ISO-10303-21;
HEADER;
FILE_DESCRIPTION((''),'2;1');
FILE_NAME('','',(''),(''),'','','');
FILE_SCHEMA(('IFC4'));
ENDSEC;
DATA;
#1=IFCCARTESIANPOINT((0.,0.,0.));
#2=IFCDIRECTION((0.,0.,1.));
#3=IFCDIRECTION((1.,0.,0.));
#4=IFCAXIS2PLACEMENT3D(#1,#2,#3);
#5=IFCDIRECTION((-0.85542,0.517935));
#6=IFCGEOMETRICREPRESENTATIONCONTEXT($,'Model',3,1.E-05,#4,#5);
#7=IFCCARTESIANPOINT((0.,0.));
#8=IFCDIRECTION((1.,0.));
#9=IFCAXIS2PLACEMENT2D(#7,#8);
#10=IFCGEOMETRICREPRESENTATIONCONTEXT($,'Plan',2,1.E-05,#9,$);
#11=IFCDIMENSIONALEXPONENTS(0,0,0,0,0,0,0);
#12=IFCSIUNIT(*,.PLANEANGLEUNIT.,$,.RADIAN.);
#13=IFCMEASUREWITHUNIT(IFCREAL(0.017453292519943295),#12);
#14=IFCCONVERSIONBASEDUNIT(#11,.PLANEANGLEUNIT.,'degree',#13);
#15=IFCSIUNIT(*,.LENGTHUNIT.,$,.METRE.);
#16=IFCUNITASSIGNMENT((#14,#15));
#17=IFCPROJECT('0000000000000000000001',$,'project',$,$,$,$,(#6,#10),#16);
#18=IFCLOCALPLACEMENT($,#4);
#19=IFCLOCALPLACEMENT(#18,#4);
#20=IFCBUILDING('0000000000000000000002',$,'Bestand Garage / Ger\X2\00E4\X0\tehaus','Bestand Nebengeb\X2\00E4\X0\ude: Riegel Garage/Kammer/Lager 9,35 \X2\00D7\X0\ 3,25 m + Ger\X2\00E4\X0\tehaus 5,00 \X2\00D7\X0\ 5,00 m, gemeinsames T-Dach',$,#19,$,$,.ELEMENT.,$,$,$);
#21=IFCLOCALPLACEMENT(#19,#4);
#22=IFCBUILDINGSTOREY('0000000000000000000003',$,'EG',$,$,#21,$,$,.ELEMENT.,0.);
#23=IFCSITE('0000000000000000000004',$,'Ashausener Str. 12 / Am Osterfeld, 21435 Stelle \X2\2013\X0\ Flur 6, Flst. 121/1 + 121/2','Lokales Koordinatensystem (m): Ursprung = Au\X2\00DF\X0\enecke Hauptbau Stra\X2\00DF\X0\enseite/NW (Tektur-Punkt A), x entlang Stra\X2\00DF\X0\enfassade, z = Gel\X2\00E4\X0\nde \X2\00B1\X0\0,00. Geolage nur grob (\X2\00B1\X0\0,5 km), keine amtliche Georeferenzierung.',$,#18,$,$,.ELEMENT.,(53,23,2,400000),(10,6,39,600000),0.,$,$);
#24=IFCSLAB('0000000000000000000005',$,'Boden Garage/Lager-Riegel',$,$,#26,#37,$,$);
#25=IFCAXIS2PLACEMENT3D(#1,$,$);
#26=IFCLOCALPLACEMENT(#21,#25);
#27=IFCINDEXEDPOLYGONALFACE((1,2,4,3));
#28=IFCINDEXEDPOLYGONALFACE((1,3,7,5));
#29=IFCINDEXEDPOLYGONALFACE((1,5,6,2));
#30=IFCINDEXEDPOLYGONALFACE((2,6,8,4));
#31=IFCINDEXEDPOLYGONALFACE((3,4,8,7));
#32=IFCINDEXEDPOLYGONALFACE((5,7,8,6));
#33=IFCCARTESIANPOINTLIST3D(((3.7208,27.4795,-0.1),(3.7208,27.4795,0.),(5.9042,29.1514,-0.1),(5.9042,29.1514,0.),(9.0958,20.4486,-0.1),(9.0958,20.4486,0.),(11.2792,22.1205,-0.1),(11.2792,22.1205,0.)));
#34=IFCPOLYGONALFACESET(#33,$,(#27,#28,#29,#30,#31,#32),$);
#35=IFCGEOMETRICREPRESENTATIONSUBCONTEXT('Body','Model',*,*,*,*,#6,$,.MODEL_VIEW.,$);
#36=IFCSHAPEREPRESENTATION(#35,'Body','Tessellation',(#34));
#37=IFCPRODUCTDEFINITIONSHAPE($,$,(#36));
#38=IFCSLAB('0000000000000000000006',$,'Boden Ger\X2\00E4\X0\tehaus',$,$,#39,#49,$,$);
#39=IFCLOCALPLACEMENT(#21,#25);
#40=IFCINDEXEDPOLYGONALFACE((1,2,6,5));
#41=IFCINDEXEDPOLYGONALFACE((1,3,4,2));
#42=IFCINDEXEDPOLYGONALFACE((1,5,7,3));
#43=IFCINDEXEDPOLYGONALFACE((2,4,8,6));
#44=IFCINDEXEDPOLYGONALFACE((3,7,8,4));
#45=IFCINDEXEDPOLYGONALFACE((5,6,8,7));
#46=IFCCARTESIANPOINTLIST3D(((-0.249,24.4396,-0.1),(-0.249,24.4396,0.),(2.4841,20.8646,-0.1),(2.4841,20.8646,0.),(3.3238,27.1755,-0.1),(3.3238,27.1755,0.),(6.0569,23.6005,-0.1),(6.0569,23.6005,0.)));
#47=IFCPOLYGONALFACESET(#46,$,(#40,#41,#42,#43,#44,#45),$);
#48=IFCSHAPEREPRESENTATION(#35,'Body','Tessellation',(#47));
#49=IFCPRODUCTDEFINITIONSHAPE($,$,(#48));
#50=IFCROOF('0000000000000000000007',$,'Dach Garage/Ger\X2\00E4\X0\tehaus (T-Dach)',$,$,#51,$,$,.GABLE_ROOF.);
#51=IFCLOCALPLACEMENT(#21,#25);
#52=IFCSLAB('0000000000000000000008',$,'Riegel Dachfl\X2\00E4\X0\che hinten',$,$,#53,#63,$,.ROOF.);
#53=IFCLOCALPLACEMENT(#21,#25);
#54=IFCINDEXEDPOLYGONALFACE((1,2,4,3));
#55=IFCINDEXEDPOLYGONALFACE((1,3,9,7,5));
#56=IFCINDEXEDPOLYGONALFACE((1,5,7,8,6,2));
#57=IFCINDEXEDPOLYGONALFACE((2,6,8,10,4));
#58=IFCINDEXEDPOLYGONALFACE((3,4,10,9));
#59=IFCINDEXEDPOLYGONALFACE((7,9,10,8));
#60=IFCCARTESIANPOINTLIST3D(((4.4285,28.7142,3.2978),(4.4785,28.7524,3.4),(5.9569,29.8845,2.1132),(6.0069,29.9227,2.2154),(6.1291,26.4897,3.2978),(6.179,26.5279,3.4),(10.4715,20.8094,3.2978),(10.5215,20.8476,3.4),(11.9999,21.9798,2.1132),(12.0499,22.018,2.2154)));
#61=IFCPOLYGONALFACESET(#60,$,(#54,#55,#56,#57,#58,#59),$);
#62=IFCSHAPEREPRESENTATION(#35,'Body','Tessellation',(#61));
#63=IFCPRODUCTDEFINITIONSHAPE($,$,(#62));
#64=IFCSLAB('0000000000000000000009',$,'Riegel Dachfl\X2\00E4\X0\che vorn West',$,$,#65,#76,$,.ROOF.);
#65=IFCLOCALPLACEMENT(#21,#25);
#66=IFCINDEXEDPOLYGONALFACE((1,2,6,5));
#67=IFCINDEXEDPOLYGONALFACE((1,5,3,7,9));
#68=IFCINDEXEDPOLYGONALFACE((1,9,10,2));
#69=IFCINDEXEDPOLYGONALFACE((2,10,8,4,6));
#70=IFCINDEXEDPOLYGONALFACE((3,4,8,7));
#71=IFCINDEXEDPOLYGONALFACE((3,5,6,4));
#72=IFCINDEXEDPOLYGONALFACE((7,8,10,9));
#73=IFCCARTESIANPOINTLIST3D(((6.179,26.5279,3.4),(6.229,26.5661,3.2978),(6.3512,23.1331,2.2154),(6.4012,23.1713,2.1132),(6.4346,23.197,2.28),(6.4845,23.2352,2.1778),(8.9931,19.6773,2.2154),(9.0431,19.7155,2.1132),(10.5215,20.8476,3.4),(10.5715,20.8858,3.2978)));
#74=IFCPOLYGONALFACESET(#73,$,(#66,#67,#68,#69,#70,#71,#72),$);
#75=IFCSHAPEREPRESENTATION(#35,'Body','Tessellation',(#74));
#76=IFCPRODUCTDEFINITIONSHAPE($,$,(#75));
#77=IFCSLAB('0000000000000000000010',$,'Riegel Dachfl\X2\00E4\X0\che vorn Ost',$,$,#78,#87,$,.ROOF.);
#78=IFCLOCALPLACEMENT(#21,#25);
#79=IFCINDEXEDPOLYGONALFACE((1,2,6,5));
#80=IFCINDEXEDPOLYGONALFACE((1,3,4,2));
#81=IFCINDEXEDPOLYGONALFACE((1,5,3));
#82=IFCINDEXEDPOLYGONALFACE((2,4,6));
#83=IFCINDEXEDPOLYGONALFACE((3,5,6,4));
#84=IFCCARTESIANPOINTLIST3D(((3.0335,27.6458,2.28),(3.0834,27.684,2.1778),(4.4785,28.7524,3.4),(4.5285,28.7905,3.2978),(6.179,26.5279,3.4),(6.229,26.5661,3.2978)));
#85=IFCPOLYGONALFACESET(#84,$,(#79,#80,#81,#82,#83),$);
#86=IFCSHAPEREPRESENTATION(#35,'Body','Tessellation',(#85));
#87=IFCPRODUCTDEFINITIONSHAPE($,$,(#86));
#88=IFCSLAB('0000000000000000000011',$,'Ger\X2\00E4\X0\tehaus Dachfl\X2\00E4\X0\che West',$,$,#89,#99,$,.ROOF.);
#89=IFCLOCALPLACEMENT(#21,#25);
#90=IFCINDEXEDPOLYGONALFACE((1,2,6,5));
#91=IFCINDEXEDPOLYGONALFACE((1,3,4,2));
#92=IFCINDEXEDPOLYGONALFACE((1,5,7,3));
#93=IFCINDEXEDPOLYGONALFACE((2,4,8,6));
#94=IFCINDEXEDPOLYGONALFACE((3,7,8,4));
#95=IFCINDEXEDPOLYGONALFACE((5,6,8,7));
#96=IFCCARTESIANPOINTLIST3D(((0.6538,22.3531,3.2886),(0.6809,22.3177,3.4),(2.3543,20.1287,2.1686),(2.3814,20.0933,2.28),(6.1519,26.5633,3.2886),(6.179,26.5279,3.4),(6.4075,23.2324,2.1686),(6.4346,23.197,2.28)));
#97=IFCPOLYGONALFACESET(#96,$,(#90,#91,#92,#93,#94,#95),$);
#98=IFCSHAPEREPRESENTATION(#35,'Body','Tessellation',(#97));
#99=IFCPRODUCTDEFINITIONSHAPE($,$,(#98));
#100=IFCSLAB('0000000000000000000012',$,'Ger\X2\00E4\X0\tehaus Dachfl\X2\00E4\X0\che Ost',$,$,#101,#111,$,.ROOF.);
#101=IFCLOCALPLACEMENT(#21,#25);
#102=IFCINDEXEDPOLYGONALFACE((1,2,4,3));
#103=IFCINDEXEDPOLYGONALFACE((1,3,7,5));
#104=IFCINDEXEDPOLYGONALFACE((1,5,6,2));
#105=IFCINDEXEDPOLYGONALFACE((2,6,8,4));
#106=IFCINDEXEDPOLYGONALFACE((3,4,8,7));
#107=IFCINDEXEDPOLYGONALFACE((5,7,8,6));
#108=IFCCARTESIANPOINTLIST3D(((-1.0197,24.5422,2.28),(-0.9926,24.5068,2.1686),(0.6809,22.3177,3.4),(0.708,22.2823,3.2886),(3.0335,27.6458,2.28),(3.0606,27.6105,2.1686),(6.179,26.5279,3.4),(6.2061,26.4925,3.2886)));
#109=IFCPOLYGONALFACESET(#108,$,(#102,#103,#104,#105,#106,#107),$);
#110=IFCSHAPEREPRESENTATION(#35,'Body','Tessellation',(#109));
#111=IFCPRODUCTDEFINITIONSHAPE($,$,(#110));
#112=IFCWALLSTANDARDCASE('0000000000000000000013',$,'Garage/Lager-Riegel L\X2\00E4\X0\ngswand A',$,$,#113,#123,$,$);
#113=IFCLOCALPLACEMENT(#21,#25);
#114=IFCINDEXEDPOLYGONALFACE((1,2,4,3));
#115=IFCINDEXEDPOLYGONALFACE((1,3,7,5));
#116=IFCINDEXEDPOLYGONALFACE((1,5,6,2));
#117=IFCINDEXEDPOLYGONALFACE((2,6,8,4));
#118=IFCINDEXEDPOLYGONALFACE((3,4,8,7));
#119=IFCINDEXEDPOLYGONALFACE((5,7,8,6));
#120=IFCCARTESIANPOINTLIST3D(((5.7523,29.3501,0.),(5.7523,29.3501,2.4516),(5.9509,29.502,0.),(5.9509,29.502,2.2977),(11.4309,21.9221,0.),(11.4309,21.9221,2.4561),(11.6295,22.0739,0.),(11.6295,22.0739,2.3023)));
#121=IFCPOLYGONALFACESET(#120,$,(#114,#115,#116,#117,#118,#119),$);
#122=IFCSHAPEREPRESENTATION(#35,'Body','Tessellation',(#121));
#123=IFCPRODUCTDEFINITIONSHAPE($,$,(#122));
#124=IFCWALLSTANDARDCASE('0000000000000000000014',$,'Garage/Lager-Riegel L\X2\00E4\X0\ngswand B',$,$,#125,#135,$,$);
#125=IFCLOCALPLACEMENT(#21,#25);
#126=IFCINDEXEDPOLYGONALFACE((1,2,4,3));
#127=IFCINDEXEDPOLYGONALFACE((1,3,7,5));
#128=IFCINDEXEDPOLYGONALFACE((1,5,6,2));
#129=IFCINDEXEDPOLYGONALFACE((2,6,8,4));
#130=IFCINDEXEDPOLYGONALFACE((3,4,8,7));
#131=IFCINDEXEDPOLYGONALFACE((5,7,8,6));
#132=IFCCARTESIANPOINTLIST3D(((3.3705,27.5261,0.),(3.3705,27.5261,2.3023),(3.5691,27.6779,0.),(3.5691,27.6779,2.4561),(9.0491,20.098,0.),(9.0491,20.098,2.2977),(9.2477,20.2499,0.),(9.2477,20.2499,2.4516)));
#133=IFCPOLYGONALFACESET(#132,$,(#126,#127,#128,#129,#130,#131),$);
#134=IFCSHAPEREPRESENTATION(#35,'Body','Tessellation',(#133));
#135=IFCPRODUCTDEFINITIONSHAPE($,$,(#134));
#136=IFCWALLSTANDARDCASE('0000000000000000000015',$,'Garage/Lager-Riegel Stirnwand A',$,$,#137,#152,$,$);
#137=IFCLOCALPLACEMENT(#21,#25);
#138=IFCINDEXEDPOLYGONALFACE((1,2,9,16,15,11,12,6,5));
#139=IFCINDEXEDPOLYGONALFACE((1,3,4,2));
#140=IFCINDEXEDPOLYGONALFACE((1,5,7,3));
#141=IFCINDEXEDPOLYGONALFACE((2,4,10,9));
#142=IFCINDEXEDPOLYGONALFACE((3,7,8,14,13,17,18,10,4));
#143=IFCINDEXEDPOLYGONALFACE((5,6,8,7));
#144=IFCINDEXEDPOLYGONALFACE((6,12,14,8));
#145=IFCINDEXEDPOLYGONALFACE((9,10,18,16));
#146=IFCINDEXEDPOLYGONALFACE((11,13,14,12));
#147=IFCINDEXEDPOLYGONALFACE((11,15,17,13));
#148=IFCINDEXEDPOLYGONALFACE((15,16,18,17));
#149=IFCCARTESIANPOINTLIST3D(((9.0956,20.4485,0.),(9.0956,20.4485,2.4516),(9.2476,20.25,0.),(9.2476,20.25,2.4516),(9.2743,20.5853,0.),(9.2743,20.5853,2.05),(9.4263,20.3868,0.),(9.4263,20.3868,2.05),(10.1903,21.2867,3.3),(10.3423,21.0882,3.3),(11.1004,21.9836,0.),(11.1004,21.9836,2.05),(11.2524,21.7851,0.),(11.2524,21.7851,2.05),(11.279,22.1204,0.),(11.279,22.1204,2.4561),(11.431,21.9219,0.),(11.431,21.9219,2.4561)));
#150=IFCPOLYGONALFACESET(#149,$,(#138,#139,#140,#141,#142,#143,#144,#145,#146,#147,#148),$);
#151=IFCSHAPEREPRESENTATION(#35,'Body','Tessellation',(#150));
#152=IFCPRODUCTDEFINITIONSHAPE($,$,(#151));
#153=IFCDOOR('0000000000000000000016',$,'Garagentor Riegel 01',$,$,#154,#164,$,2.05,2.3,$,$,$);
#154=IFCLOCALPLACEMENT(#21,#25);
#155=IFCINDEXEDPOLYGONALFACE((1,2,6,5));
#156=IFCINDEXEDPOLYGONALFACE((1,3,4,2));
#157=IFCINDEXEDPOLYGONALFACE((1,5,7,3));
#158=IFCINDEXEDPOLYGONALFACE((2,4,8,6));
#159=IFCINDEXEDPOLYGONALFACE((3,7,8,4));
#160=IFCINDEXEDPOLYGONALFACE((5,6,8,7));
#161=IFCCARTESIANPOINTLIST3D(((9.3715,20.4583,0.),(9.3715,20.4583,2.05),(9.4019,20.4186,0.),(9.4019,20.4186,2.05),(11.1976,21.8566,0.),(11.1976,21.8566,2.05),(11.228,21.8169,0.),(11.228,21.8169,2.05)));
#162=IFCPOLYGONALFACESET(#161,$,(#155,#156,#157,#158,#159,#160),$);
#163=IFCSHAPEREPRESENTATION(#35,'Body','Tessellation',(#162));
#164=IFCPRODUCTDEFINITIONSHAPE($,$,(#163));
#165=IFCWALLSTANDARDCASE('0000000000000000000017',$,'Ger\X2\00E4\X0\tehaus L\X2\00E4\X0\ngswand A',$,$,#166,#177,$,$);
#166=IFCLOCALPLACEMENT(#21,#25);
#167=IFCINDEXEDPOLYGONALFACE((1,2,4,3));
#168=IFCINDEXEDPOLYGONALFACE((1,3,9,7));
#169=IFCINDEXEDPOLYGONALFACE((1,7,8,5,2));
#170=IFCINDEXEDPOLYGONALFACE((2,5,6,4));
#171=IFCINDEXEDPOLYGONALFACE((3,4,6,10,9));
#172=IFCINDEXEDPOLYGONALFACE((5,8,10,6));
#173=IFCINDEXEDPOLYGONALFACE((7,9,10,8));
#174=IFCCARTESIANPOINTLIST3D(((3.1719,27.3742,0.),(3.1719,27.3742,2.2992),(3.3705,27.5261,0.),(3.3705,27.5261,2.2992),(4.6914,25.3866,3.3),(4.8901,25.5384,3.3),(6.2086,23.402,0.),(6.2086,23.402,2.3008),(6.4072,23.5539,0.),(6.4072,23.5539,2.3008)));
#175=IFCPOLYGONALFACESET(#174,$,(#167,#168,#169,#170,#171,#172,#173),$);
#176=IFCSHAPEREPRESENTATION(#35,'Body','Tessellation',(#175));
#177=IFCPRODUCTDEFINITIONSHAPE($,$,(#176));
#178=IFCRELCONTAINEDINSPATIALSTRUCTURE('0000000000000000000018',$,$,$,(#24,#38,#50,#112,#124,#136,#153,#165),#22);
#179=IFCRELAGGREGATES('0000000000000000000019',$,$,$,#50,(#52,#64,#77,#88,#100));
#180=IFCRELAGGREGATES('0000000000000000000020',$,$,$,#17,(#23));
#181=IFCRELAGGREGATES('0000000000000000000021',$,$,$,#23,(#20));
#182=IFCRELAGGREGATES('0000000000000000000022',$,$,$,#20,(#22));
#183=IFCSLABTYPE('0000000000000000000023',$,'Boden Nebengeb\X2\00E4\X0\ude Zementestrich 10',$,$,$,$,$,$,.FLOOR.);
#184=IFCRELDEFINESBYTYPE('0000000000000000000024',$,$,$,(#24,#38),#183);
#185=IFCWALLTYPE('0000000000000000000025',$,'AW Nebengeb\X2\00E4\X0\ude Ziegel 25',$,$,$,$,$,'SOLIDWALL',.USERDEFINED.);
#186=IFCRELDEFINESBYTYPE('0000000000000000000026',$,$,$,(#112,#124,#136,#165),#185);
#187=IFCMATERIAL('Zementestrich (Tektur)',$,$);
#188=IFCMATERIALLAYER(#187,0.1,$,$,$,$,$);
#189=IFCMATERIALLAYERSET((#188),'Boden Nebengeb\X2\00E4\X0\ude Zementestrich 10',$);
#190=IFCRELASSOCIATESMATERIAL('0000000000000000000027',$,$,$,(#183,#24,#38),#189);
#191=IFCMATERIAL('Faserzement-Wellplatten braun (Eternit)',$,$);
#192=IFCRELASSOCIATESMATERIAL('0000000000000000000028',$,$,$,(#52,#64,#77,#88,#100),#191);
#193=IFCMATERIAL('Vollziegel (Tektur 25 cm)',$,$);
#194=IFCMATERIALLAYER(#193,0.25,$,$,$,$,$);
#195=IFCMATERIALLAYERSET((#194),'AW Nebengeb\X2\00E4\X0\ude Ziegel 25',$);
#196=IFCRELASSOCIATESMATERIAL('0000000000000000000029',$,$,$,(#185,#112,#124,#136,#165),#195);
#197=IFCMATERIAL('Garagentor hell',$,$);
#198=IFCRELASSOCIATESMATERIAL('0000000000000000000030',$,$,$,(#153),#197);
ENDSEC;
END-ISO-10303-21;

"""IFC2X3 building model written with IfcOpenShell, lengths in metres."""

from ifc_helpers import new_model, entity, si_unit, converted_unit, direction, frame, origin_with_axes, origin_2d_with_axis, place, context, subcontext, project, spatial, polyline, outline, extrude, clip, halfspace, material, layer, layer_set, layer_usage, type_object, element, fill, aggregate, save


model = new_model("IFC2X3")

# Units and contexts
model_context = context("Model", 3, precision=1e-05, world=origin_with_axes(), true_north=direction((-0.85542, 0.517935)))
plan_context = context("Plan", 2, precision=1e-05, world=origin_2d_with_axis())
body_context = subcontext(model_context, "Body", "Model", "MODEL_VIEW")
ifc_project = project(units=[converted_unit("PLANEANGLEUNIT", "degree", entity("IfcReal", 0.017453292519943295), si_unit("PLANEANGLEUNIT", "RADIAN"), dimensions=[0, 0, 0, 0, 0, 0, 0]), si_unit("LENGTHUNIT", "METRE")], contexts=[model_context, plan_context])

# Site, building, storey
site_placement = place(None, origin_with_axes())
site = spatial("IfcSite", under=ifc_project, at=site_placement, Name="Ashausener Str. 12 / Am Osterfeld, 21435 Stelle – Flur 6, Flst. 121/1 + 121/2", Description="Lokales Koordinatensystem (m): Ursprung = Außenecke Hauptbau Straßenseite/NW (Tektur-Punkt A), x entlang Straßenfassade, z = Gelände ±0,00. Geolage nur grob (±0,5 km), keine amtliche Georeferenzierung.", CompositionType="ELEMENT", RefLatitude=(53, 23, 2, 400000), RefLongitude=(10, 6, 39, 600000), RefElevation=0.0)
building_placement = place(site_placement, origin_with_axes())
building = spatial("IfcBuilding", under=site, at=building_placement, Name="Bestand Garage / Gerätehaus", Description="Bestand Nebengebäude: Riegel Garage/Kammer/Lager 9,35 × 3,25 m + Gerätehaus 5,00 × 5,00 m, gemeinsames T-Dach", CompositionType="ELEMENT")
storey_placement = place(building_placement, origin_with_axes())
storey = spatial("IfcBuildingStorey", under=building, at=storey_placement, Name="EG", CompositionType="ELEMENT", Elevation=0.0)

# Slabs
ifc_material_1 = material(Name="Zementestrich (Tektur)")
ifc_layer_1 = layer(ifc_material_1, 0.1)
ifc_layer_set_1 = layer_set([ifc_layer_1], Name="Boden Nebengebäude Zementestrich 10")
ifc_layer_usage_1 = layer_usage(ifc_layer_set_1, "AXIS3", "POSITIVE", 0.0)
slab_type = type_object("IfcSlabType", Name="Boden Nebengebäude Zementestrich 10", PredefinedType="FLOOR", material=ifc_layer_set_1)
slab_1_placement = place(storey_placement, origin_with_axes())
element("IfcSlab", 1, at=slab_1_placement, inside=storey, type_object=slab_type, material=ifc_layer_usage_1, Name="Boden Garage/Lager-Riegel", context=body_context, shape_type="SweptSolid", body=[
    extrude(outline(polyline([(11.2792, 22.1205), (5.9042, 29.1514), (3.7208, 27.4795), (9.0958, 20.4486), (11.2792, 22.1205)])), frame((0.0, 0.0, -0.1)), (0.0, 0.0, 1.0), 0.1),
])
ifc_layer_usage_2 = layer_usage(ifc_layer_set_1, "AXIS3", "POSITIVE", 0.0)
slab_2_placement = place(storey_placement, origin_with_axes())
element("IfcSlab", 2, at=slab_2_placement, inside=storey, type_object=slab_type, material=ifc_layer_usage_2, Name="Boden Gerätehaus", context=body_context, shape_type="SweptSolid", body=[
    extrude(outline(polyline([(6.0569, 23.6005), (3.3238, 27.1755), (-0.249, 24.4396), (2.4841, 20.8646), (6.0569, 23.6005)])), frame((0.0, 0.0, -0.1)), (0.0, 0.0, 1.0), 0.1),
])

# Roof, slabs
roof_placement = place(storey_placement, origin_with_axes())
roof = element("IfcRoof", 3, at=roof_placement, inside=storey, Name="Dach Garage/Gerätehaus (T-Dach)", ShapeType="GABLE_ROOF")
ifc_material_2 = material(Name="Faserzement-Wellplatten braun (Eternit)")
slab_3_placement = place(roof_placement, origin_with_axes())
slab_3 = element("IfcSlab", 4, at=slab_3_placement, material=ifc_material_2, Name="Riegel Dachfläche hinten", PredefinedType="ROOF", context=body_context, shape_type="SweptSolid", body=[
    extrude(outline(polyline([(0.0, 0.0), (9.95, 0.0), (9.9485, 2.2603), (7.1485, 2.2603), (-0.0015, 2.2603), (0.0, 0.0)])), frame((12.0499, 22.018, 2.2154), z_axis=(0.416367, 0.318306, 0.851657), x_axis=(-0.607339, 0.794443, 0.0)), (0.0, 0.0, -1.0), 0.12),
])
slab_4_placement = place(roof_placement, origin_with_axes())
slab_4 = element("IfcSlab", 5, at=slab_4_placement, material=ifc_material_2, Name="Riegel Dachfläche vorn West", PredefinedType="ROOF", context=body_context, shape_type="SweptSolid", body=[
    extrude(outline(polyline([(0.0, 0.0), (7.15, 0.0), (4.3486, 2.137), (4.3485, 2.2603), (-0.0015, 2.2603), (0.0, 0.0)])), frame((10.5215, 20.8476, 3.4), z_axis=(-0.416366, -0.318306, 0.851658), x_axis=(-0.607339, 0.794443, 0.0)), (0.0, 0.0, -1.0), 0.12),
])
slab_5_placement = place(roof_placement, origin_with_axes())
slab_5 = element("IfcSlab", 6, at=slab_5_placement, material=ifc_material_2, Name="Riegel Dachfläche vorn Ost", PredefinedType="ROOF", context=body_context, shape_type="SweptSolid", body=[
    extrude(outline(polyline([(0.0, 0.0), (2.8, 0.0), (2.7986, 2.137), (0.0, 0.0)])), frame((6.179, 26.5279, 3.4), z_axis=(-0.416366, -0.318305, 0.851658), x_axis=(-0.607339, 0.794443, 0.0)), (0.0, 0.0, -1.0), 0.12),
])
slab_6_placement = place(roof_placement, origin_with_axes())
slab_6 = element("IfcSlab", 7, at=slab_6_placement, material=ifc_material_2, Name="Gerätehaus Dachfläche West", PredefinedType="ROOF", context=body_context, shape_type="SweptSolid", body=[
    extrude(outline(polyline([(0.0, 0.0), (6.925, 0.0), (6.9272, 3.0157), (1.8222, 3.0157), (0.0, 0.0)])), frame((6.179, 26.5279, 3.4), z_axis=(0.225794, -0.294869, 0.928477), x_axis=(-0.79396, -0.60797, 0.0)), (0.0, 0.0, -1.0), 0.12),
])
slab_7_placement = place(roof_placement, origin_with_axes())
slab_7 = element("IfcSlab", 8, at=slab_7_placement, material=ifc_material_2, Name="Gerätehaus Dachfläche Ost", PredefinedType="ROOF", context=body_context, shape_type="SweptSolid", body=[
    extrude(outline(polyline([(0.0, 0.0), (3.5212, 0.0), (6.1566, 4.3721), (3.575, 5.9309), (0.0, 0.0)])), frame((6.179, 26.5279, 3.4), z_axis=(-0.225794, 0.294869, 0.928477), x_axis=(-0.893325, 0.317489, -0.318075)), (0.0, 0.0, -1.0), 0.12),
])
aggregate(roof, [slab_3, slab_4, slab_5, slab_6, slab_7])

# Walls
ifc_material_3 = material(Name="Vollziegel (Tektur 25 cm)")
ifc_layer_2 = layer(ifc_material_3, 0.25)
ifc_layer_set_2 = layer_set([ifc_layer_2], Name="AW Nebengebäude Ziegel 25")
ifc_layer_usage_3 = layer_usage(ifc_layer_set_2, "AXIS2", "POSITIVE", 0.0)
wall_type = type_object("IfcWallType", Name="AW Nebengebäude Ziegel 25", ElementType="SOLIDWALL", PredefinedType="USERDEFINED", material=ifc_layer_set_2)
wall_1_placement = place(storey_placement, frame((11.6295, 22.0739, 0.0), z_axis=(0.0, 0.0, 1.0), x_axis=(-0.607339, 0.794443, 0.0)))
element("IfcWallStandardCase", 9, at=wall_1_placement, inside=storey, type_object=wall_type, material=ifc_layer_usage_3, Name="Garage/Lager-Riegel Längswand A", context=body_context, shape_type="Clipping", body=[
    clip(clip(extrude(outline(polyline([(0.0, 0.0), (0.0, 0.25), (9.35, 0.25), (9.35, 0.0), (0.0, 0.0)])), origin_with_axes(), (0.0, 0.0, 1.0), 6.0), halfspace(frame((4.6724, 3.25, 2.3), z_axis=(-0.000416, 0.5241, 0.85166), x_axis=(1.0, 0.000795, 0.0)), False)), halfspace(frame((4.675, 0.0, 2.3), z_axis=(0.000416, -0.5241, 0.85166), x_axis=(-1.0, -0.000795, 0.0)), False)),
])
ifc_layer_usage_4 = layer_usage(ifc_layer_set_2, "AXIS2", "POSITIVE", 0.0)
wall_2_placement = place(storey_placement, frame((3.3705, 27.5261, 0.0), z_axis=(0.0, 0.0, 1.0), x_axis=(0.607339, -0.794443, 0.0)))
element("IfcWallStandardCase", 10, at=wall_2_placement, inside=storey, type_object=wall_type, material=ifc_layer_usage_4, Name="Garage/Lager-Riegel Längswand B", context=body_context, shape_type="Clipping", body=[
    clip(clip(extrude(outline(polyline([(0.0, 0.0), (0.0, 0.25), (9.35, 0.25), (9.35, 0.0), (0.0, 0.0)])), origin_with_axes(), (0.0, 0.0, 1.0), 6.0), halfspace(frame((4.675, 0.0, 2.3), z_axis=(0.000416, -0.5241, 0.85166), x_axis=(-1.0, -0.000795, 0.0)), False)), halfspace(frame((4.6724, 3.25, 2.3), z_axis=(-0.000416, 0.5241, 0.85166), x_axis=(1.0, 0.000795, 0.0)), False)),
])

# Wall, opening, door
ifc_layer_usage_5 = layer_usage(ifc_layer_set_2, "AXIS2", "POSITIVE", 0.0)
wall_3_placement = place(storey_placement, frame((9.2476, 20.25, 0.0), z_axis=(0.0, 0.0, 1.0), x_axis=(0.79396, 0.60797, 0.0)))
wall_3 = element("IfcWallStandardCase", 11, at=wall_3_placement, inside=storey, type_object=wall_type, material=ifc_layer_usage_5, Name="Garage/Lager-Riegel Stirnwand A", context=body_context, shape_type="Clipping", body=[
    clip(clip(extrude(outline(polyline([(0.0, 0.0), (0.0, 0.25), (2.75, 0.25), (2.75, 0.0), (0.0, 0.0)])), origin_with_axes(), (0.0, 0.0, 1.0), 6.0), halfspace(frame((-0.2463, 4.675, 2.3), z_axis=(-0.5241, 0.0, 0.85166), x_axis=(0.0, 1.0, 0.0)), False)), halfspace(frame((3.0037, 4.675, 2.3), z_axis=(0.5241, 0.0, 0.85166), x_axis=(0.0, -1.0, 0.0)), False)),
])
opening_1_placement = place(wall_3_placement, frame((0.225, -0.1, 0.0), z_axis=(0.0, 0.0, 1.0), x_axis=(1.0, 0.0, 0.0)))
opening_1 = element("IfcOpeningElement", 12, at=opening_1_placement, cuts=wall_3, context=body_context, shape_type="SweptSolid", body=[
    extrude(outline(polyline([(0.0, 0.0), (0.0, 0.45), (2.3, 0.45), (2.3, 0.0), (0.0, 0.0)])), origin_with_axes(), (0.0, 0.0, 1.0), 2.05),
])
ifc_material_4 = material(Name="Garagentor hell")
door_1_placement = place(storey_placement, frame((9.4019, 20.4186, 0.0), z_axis=(0.0, 0.0, 1.0), x_axis=(0.79396, 0.60797, 0.0)))
door_1 = element("IfcDoor", 13, at=door_1_placement, inside=storey, material=ifc_material_4, Name="Garagentor Riegel 01", OverallHeight=2.05, OverallWidth=2.3, context=body_context, shape_type="SweptSolid", body=[
    extrude(outline(polyline([(0.0, 0.0), (0.0, 0.05), (2.3, 0.05), (2.3, 0.0), (0.0, 0.0)])), origin_with_axes(), (0.0, 0.0, 1.0), 2.05),
])
fill(opening_1, door_1)

# Wall
ifc_layer_usage_6 = layer_usage(ifc_layer_set_2, "AXIS2", "POSITIVE", 0.0)
wall_4_placement = place(storey_placement, frame((6.4072, 23.5539, 0.0), z_axis=(0.0, 0.0, 1.0), x_axis=(-0.607339, 0.794443, 0.0)))
element("IfcWallStandardCase", 14, at=wall_4_placement, inside=storey, type_object=wall_type, material=ifc_layer_usage_6, Name="Gerätehaus Längswand A", context=body_context, shape_type="Clipping", body=[
    clip(clip(extrude(outline(polyline([(0.0, 0.0), (0.0, 0.25), (5.0, 0.25), (5.0, 0.0), (0.0, 0.0)])), origin_with_axes(), (0.0, 0.0, 1.0), 6.0), halfspace(frame((4.998, 2.5, 2.3), z_axis=(0.37139, 0.0, 0.92848), x_axis=(0.0, -1.0, 0.0)), False)), halfspace(frame((-0.002, 2.5, 2.3), z_axis=(-0.37139, 0.0, 0.92848), x_axis=(0.0, 1.0, 0.0)), False)),
])

save(model, "model.ifc")
